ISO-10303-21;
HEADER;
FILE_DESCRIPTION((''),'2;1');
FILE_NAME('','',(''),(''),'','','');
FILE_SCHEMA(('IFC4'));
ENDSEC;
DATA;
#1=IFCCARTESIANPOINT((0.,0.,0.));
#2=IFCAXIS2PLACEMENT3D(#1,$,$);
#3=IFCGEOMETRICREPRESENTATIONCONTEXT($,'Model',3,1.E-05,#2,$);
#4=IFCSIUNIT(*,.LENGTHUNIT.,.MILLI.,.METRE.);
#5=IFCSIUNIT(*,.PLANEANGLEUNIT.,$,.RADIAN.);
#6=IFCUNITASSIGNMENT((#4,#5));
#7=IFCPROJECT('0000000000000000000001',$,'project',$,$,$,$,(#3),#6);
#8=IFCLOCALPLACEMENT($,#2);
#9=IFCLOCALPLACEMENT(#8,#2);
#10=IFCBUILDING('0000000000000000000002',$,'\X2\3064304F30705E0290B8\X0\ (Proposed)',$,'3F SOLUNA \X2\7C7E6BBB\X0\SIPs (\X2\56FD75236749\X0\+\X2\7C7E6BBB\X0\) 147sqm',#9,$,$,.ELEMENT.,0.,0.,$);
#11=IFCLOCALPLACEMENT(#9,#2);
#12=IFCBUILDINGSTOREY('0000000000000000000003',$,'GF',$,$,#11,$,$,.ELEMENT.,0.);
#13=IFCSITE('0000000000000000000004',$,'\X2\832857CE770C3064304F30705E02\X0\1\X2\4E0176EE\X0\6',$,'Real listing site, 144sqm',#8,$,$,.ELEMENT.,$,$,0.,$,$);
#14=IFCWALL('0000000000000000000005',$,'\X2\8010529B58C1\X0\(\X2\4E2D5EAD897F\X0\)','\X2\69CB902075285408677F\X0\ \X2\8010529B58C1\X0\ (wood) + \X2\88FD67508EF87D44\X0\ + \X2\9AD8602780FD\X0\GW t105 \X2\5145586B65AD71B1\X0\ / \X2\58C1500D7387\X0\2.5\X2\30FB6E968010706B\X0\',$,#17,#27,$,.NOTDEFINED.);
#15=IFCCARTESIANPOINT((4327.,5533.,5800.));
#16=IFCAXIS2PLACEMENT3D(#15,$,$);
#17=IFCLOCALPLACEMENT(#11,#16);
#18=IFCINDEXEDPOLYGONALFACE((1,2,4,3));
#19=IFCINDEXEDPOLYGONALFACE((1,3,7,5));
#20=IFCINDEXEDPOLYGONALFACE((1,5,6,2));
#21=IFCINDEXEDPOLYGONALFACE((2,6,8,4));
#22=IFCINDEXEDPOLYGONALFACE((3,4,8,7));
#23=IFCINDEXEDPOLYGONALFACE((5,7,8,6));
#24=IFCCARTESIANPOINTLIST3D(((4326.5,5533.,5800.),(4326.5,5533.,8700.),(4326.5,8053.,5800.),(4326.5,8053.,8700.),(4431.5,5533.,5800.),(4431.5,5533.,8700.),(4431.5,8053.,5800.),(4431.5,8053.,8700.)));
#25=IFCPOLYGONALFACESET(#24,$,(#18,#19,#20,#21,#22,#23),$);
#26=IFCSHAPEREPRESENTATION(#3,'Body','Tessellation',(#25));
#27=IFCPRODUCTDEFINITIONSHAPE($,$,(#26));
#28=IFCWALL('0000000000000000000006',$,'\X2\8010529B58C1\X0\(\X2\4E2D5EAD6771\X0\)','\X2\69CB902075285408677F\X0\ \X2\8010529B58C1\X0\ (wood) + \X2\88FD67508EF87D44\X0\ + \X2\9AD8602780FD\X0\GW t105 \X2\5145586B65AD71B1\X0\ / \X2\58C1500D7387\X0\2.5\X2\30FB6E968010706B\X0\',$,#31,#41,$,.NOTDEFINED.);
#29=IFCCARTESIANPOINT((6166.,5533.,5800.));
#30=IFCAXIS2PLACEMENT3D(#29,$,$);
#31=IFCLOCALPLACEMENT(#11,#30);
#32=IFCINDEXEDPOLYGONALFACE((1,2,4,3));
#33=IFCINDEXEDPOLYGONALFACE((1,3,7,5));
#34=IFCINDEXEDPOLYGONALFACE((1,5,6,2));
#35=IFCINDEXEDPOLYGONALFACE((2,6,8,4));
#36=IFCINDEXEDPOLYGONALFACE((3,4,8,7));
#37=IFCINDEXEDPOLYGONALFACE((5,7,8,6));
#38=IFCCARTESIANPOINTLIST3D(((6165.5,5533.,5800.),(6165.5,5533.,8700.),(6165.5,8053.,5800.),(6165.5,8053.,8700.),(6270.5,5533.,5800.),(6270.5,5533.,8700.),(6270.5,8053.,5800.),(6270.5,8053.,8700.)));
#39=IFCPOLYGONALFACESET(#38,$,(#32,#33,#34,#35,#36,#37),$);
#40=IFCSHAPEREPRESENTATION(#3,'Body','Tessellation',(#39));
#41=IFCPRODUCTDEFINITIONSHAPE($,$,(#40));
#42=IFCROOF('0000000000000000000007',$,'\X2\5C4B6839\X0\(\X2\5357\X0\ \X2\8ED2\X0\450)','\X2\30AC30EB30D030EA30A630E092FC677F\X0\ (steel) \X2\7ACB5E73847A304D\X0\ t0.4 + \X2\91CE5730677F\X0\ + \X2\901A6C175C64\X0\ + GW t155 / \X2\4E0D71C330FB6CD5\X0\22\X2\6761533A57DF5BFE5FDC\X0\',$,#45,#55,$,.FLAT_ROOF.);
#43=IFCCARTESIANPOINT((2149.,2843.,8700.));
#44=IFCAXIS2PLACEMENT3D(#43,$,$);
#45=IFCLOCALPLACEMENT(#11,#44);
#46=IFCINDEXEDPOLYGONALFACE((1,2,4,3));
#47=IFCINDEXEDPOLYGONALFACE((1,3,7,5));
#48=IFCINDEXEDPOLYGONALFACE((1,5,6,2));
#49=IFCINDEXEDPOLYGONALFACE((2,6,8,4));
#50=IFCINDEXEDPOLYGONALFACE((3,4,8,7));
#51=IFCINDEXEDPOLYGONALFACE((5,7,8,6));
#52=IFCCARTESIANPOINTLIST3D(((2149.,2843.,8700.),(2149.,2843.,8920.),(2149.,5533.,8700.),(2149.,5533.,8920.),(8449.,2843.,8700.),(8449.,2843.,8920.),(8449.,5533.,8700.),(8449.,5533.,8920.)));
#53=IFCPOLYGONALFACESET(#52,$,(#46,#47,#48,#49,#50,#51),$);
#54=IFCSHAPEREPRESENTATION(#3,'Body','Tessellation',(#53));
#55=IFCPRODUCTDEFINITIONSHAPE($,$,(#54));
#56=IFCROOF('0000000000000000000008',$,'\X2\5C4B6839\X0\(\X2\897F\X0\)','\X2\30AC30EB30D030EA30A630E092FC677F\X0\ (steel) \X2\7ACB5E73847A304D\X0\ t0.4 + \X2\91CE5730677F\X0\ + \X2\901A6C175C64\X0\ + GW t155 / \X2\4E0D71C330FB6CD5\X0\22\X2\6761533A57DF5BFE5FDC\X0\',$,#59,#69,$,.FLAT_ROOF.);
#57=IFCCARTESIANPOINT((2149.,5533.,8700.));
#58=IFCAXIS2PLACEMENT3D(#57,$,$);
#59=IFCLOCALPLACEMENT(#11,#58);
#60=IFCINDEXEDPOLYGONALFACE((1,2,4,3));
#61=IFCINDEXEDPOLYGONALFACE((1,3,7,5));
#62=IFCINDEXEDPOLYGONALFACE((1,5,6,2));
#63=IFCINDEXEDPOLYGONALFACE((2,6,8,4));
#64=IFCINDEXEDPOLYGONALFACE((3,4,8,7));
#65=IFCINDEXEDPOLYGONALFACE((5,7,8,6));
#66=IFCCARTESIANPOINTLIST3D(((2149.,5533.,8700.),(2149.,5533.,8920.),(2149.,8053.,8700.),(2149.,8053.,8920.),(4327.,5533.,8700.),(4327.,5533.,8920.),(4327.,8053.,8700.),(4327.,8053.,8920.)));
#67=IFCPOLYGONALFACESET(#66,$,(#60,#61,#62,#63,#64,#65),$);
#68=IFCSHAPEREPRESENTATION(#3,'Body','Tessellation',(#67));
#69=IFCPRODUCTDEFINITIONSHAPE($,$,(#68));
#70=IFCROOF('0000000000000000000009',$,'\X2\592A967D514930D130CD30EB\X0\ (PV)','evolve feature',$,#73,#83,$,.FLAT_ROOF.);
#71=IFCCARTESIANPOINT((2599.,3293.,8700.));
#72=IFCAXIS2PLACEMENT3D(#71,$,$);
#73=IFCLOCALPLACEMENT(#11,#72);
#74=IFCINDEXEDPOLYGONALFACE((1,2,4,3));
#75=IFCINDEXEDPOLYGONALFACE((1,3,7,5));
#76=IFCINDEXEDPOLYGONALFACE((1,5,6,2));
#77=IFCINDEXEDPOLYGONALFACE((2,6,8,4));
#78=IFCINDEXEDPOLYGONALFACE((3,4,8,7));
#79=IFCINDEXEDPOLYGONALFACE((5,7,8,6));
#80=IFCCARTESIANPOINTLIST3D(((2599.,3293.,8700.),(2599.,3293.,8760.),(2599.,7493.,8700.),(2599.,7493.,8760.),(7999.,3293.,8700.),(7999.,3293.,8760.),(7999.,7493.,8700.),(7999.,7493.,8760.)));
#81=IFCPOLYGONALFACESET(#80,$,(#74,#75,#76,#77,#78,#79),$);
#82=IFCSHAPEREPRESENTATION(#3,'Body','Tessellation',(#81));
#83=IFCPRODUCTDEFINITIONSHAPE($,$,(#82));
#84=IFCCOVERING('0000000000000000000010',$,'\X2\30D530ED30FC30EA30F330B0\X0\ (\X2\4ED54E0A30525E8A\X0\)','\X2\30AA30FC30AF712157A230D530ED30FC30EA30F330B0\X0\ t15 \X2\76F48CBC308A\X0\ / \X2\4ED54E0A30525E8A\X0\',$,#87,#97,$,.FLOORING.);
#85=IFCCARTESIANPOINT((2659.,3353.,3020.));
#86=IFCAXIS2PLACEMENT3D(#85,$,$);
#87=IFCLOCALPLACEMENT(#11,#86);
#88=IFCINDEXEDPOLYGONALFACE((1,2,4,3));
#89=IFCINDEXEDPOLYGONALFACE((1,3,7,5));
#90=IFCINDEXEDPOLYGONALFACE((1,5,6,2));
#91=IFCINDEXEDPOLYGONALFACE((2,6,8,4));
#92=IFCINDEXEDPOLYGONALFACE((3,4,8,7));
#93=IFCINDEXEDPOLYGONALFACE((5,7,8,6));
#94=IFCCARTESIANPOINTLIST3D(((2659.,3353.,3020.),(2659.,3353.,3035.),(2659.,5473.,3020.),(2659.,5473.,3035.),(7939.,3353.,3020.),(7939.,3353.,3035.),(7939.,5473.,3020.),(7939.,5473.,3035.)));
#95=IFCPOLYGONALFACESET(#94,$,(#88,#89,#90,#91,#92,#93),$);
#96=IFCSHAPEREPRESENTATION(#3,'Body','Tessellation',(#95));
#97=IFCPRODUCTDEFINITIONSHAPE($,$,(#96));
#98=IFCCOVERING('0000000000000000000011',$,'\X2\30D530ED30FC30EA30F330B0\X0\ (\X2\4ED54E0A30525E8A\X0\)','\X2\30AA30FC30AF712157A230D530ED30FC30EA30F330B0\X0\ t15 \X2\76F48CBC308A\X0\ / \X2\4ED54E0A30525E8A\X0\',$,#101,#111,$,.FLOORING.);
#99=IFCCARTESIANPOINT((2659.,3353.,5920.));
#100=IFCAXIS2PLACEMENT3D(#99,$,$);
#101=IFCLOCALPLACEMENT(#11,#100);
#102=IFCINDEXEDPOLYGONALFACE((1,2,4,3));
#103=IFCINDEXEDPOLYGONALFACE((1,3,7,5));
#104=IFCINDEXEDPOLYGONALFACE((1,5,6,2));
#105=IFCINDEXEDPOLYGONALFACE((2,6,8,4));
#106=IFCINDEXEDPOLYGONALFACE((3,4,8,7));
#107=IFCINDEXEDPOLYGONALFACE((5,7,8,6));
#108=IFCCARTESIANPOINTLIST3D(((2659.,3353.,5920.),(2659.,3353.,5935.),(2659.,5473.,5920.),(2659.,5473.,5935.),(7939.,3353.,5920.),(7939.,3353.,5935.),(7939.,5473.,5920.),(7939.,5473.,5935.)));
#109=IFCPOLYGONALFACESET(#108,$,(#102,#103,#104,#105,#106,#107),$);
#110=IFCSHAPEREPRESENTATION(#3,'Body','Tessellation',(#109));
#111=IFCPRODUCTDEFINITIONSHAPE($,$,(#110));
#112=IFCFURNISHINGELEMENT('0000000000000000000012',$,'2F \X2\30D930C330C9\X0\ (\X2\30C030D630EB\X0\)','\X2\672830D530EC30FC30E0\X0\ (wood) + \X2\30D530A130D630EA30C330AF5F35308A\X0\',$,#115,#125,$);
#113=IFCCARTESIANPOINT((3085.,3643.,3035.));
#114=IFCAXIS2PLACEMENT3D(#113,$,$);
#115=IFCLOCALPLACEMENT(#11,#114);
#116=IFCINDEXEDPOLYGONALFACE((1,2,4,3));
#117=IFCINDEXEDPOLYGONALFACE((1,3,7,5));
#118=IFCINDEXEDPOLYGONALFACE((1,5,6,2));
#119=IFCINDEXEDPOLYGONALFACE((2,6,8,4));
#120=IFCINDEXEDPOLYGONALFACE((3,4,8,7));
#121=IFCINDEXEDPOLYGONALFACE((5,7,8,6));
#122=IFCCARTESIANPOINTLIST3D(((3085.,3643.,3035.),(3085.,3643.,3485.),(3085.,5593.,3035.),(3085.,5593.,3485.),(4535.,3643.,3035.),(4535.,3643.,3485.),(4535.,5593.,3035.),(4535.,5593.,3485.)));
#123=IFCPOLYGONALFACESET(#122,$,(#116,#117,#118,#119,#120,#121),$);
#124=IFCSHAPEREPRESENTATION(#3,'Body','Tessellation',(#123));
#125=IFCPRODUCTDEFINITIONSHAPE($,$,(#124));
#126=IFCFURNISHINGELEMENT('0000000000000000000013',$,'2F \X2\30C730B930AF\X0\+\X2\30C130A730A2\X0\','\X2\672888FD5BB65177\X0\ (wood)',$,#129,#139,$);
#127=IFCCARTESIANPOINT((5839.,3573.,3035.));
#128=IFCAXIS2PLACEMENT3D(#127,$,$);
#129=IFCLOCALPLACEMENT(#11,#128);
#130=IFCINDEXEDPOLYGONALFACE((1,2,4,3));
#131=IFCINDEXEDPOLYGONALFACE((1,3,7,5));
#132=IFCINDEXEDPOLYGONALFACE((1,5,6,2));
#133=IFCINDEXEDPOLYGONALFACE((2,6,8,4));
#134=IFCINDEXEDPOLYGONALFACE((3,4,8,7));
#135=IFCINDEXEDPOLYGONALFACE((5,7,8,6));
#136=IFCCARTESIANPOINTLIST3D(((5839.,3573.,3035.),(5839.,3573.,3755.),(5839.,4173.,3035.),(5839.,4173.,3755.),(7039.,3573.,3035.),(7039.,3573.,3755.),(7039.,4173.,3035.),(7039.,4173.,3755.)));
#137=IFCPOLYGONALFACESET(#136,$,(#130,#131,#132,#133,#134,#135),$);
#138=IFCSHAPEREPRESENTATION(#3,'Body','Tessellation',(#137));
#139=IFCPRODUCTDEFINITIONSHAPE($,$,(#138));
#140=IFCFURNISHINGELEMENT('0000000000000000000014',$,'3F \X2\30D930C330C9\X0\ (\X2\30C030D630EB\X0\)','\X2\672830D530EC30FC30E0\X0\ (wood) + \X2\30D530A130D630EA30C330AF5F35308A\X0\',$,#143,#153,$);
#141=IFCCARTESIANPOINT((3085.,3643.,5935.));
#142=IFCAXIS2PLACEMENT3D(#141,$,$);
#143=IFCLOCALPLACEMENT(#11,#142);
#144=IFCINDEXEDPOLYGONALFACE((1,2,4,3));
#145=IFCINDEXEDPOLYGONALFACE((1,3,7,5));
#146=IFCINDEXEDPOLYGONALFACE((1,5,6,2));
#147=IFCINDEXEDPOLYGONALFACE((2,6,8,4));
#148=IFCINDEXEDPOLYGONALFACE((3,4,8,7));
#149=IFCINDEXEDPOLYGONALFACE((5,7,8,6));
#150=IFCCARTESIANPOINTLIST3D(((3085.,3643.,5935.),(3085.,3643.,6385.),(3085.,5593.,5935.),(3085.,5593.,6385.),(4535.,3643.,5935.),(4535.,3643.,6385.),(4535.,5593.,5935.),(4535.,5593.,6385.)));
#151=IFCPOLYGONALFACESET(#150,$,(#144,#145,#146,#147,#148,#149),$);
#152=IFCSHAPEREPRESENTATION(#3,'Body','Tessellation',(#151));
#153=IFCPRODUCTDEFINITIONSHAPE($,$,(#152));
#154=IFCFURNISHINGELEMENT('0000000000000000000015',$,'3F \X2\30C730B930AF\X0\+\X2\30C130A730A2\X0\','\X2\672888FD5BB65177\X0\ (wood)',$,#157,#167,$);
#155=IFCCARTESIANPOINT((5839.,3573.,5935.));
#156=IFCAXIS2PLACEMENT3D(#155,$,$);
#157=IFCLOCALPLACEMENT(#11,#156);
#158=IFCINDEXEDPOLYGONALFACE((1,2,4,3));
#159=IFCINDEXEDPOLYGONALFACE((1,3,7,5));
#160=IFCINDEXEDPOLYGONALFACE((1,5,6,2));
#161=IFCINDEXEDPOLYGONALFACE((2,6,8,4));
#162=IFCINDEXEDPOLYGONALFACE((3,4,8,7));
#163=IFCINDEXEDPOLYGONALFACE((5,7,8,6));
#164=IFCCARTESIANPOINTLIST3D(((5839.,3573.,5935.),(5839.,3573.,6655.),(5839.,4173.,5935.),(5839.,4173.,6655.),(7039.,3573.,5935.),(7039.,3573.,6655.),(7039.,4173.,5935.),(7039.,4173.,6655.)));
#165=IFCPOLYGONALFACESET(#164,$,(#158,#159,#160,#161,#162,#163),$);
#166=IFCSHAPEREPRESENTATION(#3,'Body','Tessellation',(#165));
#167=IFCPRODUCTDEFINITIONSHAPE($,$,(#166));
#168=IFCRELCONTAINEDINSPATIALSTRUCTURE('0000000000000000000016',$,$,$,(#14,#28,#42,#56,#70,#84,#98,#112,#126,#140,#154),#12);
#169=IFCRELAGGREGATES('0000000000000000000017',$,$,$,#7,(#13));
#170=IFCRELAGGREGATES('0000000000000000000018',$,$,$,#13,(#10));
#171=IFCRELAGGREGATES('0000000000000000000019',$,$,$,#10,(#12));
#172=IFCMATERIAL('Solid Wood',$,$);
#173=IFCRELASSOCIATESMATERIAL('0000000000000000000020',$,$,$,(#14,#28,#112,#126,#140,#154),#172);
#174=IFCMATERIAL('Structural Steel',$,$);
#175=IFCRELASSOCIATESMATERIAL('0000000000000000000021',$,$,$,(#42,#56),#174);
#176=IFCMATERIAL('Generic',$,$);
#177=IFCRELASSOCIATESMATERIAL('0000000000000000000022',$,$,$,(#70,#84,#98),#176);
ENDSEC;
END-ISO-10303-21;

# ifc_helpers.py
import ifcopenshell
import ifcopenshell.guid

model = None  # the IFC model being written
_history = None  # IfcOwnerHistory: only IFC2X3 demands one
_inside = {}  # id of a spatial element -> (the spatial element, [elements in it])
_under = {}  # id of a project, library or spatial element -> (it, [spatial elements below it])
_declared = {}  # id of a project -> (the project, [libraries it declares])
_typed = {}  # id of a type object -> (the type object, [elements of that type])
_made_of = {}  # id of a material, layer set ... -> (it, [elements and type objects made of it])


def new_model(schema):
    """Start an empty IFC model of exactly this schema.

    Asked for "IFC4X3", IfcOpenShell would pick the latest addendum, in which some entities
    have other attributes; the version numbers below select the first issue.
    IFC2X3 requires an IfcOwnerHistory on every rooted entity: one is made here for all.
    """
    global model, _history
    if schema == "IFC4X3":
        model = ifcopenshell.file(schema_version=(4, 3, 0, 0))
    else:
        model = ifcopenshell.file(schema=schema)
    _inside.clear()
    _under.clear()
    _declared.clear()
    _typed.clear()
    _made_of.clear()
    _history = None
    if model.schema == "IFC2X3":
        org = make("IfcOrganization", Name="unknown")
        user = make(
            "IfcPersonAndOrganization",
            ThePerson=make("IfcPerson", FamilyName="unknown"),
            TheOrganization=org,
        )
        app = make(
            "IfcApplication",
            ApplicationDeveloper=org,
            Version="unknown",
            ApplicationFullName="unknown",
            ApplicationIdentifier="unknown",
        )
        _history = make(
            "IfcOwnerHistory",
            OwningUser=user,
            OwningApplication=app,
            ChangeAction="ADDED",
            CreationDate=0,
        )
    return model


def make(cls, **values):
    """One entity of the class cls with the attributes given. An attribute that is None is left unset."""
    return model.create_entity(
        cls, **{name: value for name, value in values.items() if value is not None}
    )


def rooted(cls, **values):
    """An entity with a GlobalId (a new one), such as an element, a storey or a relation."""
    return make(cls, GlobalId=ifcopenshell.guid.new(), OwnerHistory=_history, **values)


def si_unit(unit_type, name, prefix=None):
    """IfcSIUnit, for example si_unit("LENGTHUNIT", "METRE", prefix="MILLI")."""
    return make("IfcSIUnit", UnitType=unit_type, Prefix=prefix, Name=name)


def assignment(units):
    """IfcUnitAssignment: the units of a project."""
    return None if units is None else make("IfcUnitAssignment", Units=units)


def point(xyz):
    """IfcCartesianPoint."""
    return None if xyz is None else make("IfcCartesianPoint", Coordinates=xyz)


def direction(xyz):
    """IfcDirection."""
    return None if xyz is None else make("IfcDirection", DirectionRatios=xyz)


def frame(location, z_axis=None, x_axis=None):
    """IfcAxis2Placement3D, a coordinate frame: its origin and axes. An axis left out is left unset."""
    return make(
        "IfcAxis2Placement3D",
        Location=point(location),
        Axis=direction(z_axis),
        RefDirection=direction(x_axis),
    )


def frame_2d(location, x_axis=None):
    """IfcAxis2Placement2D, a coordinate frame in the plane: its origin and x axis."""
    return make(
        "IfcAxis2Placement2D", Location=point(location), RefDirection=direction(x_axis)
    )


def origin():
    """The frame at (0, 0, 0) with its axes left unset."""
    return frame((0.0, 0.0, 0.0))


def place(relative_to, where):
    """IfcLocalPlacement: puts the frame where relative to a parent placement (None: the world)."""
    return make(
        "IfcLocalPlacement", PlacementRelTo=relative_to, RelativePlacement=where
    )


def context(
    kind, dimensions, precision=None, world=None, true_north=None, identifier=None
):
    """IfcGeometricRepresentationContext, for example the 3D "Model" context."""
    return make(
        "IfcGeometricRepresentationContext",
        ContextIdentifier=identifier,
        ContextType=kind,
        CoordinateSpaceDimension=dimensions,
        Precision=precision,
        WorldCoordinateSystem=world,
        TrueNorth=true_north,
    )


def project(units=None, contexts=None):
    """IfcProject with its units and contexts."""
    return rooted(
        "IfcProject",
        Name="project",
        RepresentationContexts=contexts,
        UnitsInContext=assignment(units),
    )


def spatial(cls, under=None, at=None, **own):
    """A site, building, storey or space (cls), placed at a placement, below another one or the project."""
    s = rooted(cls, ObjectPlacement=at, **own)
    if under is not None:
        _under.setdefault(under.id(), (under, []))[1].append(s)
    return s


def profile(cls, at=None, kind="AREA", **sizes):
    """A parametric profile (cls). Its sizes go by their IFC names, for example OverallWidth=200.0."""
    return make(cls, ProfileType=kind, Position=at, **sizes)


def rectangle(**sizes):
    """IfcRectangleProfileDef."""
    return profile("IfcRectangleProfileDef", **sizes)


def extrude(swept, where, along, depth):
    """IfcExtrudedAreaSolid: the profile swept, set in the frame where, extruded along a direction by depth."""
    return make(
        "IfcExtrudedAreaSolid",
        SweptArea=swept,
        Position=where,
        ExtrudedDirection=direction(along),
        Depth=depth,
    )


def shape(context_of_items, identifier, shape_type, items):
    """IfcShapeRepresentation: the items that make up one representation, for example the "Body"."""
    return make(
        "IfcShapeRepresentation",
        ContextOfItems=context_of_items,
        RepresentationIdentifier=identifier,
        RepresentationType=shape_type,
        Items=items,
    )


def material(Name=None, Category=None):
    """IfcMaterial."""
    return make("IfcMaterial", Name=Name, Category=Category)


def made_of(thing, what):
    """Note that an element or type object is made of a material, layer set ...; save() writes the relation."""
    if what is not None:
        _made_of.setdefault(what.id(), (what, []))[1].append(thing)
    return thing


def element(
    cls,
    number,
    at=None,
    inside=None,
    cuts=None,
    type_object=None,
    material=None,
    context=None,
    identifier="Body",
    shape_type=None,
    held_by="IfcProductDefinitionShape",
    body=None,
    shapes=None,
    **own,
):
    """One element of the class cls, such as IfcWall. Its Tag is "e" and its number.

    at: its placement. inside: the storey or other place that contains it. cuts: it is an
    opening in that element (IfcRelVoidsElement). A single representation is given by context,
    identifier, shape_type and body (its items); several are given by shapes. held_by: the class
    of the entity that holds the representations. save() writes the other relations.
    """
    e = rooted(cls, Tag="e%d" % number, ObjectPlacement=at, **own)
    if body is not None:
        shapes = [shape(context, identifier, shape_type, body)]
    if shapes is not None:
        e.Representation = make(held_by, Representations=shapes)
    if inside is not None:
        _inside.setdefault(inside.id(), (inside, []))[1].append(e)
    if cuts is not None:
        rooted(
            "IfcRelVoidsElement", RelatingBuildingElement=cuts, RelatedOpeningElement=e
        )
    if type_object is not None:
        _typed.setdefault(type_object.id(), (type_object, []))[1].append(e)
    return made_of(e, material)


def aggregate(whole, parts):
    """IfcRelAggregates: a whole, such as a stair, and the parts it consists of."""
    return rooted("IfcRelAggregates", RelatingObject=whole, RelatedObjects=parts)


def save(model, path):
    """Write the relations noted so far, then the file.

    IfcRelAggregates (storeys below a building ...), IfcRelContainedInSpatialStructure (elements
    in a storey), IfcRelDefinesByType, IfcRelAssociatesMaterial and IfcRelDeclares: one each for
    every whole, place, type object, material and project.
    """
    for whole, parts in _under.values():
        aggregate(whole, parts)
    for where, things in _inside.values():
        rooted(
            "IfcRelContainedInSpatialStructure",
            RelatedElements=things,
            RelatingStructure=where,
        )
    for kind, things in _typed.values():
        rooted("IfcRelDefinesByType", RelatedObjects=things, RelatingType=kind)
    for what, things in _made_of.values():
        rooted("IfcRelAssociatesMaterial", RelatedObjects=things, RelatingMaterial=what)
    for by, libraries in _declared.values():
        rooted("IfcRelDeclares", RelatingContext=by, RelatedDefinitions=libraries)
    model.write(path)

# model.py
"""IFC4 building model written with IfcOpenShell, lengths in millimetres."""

from ifc_helpers import new_model, si_unit, frame, frame_2d, origin, place, context, project, spatial, rectangle, extrude, material, element, save


model = new_model("IFC4")

# Units and contexts
model_context = context("Model", 3, precision=1e-05, world=origin())
ifc_project = project(units=[si_unit("LENGTHUNIT", "METRE", prefix="MILLI"), si_unit("PLANEANGLEUNIT", "RADIAN")], contexts=[model_context])

# Site, building, storey
site_placement = place(None, origin())
site = spatial("IfcSite", under=ifc_project, at=site_placement, Name="茨城県つくば市1丁目6", ObjectType="Real listing site, 144sqm", CompositionType="ELEMENT", RefElevation=0.0)
building_placement = place(site_placement, origin())
building = spatial("IfcBuilding", under=site, at=building_placement, Name="つくば市邸 (Proposed)", ObjectType="3F SOLUNA 籾殻SIPs (国産杉+籾殻) 147sqm", CompositionType="ELEMENT", ElevationOfRefHeight=0.0, ElevationOfTerrain=0.0)
storey_placement = place(building_placement, origin())
storey = spatial("IfcBuildingStorey", under=building, at=storey_placement, Name="GF", CompositionType="ELEMENT", Elevation=0.0)

# Shared definitions
ifc_material_1 = material(Name="Solid Wood")

# Walls
wall_1_placement = place(storey_placement, frame((4327.0, 5533.0, 5800.0)))
element("IfcWall", 1, at=wall_1_placement, inside=storey, material=ifc_material_1, Name="耐力壁(中庭西)", Description="構造用合板 耐力壁 (wood) + 製材軸組 + 高性能GW t105 充填断熱 / 壁倍率2.5・準耐火", PredefinedType="NOTDEFINED", context=model_context, shape_type="SweptSolid", body=[
    extrude(rectangle(XDim=105.0, YDim=2520.0, at=frame_2d((52.0, 1260.0))), frame((4327.0, 5533.0, 5800.0)), (0.0, 0.0, 1.0), 2900.0),
])
wall_2_placement = place(storey_placement, frame((6166.0, 5533.0, 5800.0)))
element("IfcWall", 2, at=wall_2_placement, inside=storey, material=ifc_material_1, Name="耐力壁(中庭東)", Description="構造用合板 耐力壁 (wood) + 製材軸組 + 高性能GW t105 充填断熱 / 壁倍率2.5・準耐火", PredefinedType="NOTDEFINED", context=model_context, shape_type="SweptSolid", body=[
    extrude(rectangle(XDim=105.0, YDim=2520.0, at=frame_2d((52.0, 1260.0))), frame((6166.0, 5533.0, 5800.0)), (0.0, 0.0, 1.0), 2900.0),
])

# Roofs
ifc_material_2 = material(Name="Structural Steel")
roof_1_placement = place(storey_placement, frame((2149.0, 2843.0, 8700.0)))
element("IfcRoof", 3, at=roof_1_placement, inside=storey, material=ifc_material_2, Name="屋根(南 軒450)", Description="ガルバリウム鋼板 (steel) 立平葺き t0.4 + 野地板 + 通気層 + GW t155 / 不燃・法22条区域対応", PredefinedType="FLAT_ROOF", context=model_context, shape_type="SweptSolid", body=[
    extrude(rectangle(XDim=6300.0, YDim=2690.0, at=frame_2d((3150.0, 1345.0))), frame((2149.0, 2843.0, 8700.0)), (0.0, 0.0, 1.0), 220.0),
])
roof_2_placement = place(storey_placement, frame((2149.0, 5533.0, 8700.0)))
element("IfcRoof", 4, at=roof_2_placement, inside=storey, material=ifc_material_2, Name="屋根(西)", Description="ガルバリウム鋼板 (steel) 立平葺き t0.4 + 野地板 + 通気層 + GW t155 / 不燃・法22条区域対応", PredefinedType="FLAT_ROOF", context=model_context, shape_type="SweptSolid", body=[
    extrude(rectangle(XDim=2178.0, YDim=2520.0, at=frame_2d((1089.0, 1260.0))), frame((2149.0, 5533.0, 8700.0)), (0.0, 0.0, 1.0), 220.0),
])
ifc_material_3 = material(Name="Generic")
roof_3_placement = place(storey_placement, frame((2599.0, 3293.0, 8700.0)))
element("IfcRoof", 5, at=roof_3_placement, inside=storey, material=ifc_material_3, Name="太陽光パネル (PV)", Description="evolve feature", PredefinedType="FLAT_ROOF", context=model_context, shape_type="SweptSolid", body=[
    extrude(rectangle(XDim=5400.0, YDim=4200.0, at=frame_2d((2700.0, 2100.0))), frame((2599.0, 3293.0, 8700.0)), (0.0, 0.0, 1.0), 60.0),
])

# Coverings
covering_1_placement = place(storey_placement, frame((2659.0, 3353.0, 3020.0)))
element("IfcCovering", 6, at=covering_1_placement, inside=storey, material=ifc_material_3, Name="フローリング (仕上げ床)", Description="オーク無垢フローリング t15 直貼り / 仕上げ床", PredefinedType="FLOORING", context=model_context, shape_type="SweptSolid", body=[
    extrude(rectangle(XDim=5280.0, YDim=2120.0, at=frame_2d((2640.0, 1060.0))), frame((2659.0, 3353.0, 3020.0)), (0.0, 0.0, 1.0), 15.0),
])
covering_2_placement = place(storey_placement, frame((2659.0, 3353.0, 5920.0)))
element("IfcCovering", 7, at=covering_2_placement, inside=storey, material=ifc_material_3, Name="フローリング (仕上げ床)", Description="オーク無垢フローリング t15 直貼り / 仕上げ床", PredefinedType="FLOORING", context=model_context, shape_type="SweptSolid", body=[
    extrude(rectangle(XDim=5280.0, YDim=2120.0, at=frame_2d((2640.0, 1060.0))), frame((2659.0, 3353.0, 5920.0)), (0.0, 0.0, 1.0), 15.0),
])

# Furnishing elements
furnishing_1_placement = place(storey_placement, frame((3085.0, 3643.0, 3035.0)))
element("IfcFurnishingElement", 8, at=furnishing_1_placement, inside=storey, material=ifc_material_1, Name="2F ベッド (ダブル)", Description="木フレーム (wood) + ファブリック張り", context=model_context, shape_type="SweptSolid", body=[
    extrude(rectangle(XDim=1450.0, YDim=1950.0, at=frame_2d((725.0, 975.0))), frame((3085.0, 3643.0, 3035.0)), (0.0, 0.0, 1.0), 450.0),
])
furnishing_2_placement = place(storey_placement, frame((5839.0, 3573.0, 3035.0)))
element("IfcFurnishingElement", 9, at=furnishing_2_placement, inside=storey, material=ifc_material_1, Name="2F デスク+チェア", Description="木製家具 (wood)", context=model_context, shape_type="SweptSolid", body=[
    extrude(rectangle(XDim=1200.0, YDim=600.0, at=frame_2d((600.0, 300.0))), frame((5839.0, 3573.0, 3035.0)), (0.0, 0.0, 1.0), 720.0),
])
furnishing_3_placement = place(storey_placement, frame((3085.0, 3643.0, 5935.0)))
element("IfcFurnishingElement", 10, at=furnishing_3_placement, inside=storey, material=ifc_material_1, Name="3F ベッド (ダブル)", Description="木フレーム (wood) + ファブリック張り", context=model_context, shape_type="SweptSolid", body=[
    extrude(rectangle(XDim=1450.0, YDim=1950.0, at=frame_2d((725.0, 975.0))), frame((3085.0, 3643.0, 5935.0)), (0.0, 0.0, 1.0), 450.0),
])
furnishing_4_placement = place(storey_placement, frame((5839.0, 3573.0, 5935.0)))
element("IfcFurnishingElement", 11, at=furnishing_4_placement, inside=storey, material=ifc_material_1, Name="3F デスク+チェア", Description="木製家具 (wood)", context=model_context, shape_type="SweptSolid", body=[
    extrude(rectangle(XDim=1200.0, YDim=600.0, at=frame_2d((600.0, 300.0))), frame((5839.0, 3573.0, 5935.0)), (0.0, 0.0, 1.0), 720.0),
])

save(model, "model.ifc")
